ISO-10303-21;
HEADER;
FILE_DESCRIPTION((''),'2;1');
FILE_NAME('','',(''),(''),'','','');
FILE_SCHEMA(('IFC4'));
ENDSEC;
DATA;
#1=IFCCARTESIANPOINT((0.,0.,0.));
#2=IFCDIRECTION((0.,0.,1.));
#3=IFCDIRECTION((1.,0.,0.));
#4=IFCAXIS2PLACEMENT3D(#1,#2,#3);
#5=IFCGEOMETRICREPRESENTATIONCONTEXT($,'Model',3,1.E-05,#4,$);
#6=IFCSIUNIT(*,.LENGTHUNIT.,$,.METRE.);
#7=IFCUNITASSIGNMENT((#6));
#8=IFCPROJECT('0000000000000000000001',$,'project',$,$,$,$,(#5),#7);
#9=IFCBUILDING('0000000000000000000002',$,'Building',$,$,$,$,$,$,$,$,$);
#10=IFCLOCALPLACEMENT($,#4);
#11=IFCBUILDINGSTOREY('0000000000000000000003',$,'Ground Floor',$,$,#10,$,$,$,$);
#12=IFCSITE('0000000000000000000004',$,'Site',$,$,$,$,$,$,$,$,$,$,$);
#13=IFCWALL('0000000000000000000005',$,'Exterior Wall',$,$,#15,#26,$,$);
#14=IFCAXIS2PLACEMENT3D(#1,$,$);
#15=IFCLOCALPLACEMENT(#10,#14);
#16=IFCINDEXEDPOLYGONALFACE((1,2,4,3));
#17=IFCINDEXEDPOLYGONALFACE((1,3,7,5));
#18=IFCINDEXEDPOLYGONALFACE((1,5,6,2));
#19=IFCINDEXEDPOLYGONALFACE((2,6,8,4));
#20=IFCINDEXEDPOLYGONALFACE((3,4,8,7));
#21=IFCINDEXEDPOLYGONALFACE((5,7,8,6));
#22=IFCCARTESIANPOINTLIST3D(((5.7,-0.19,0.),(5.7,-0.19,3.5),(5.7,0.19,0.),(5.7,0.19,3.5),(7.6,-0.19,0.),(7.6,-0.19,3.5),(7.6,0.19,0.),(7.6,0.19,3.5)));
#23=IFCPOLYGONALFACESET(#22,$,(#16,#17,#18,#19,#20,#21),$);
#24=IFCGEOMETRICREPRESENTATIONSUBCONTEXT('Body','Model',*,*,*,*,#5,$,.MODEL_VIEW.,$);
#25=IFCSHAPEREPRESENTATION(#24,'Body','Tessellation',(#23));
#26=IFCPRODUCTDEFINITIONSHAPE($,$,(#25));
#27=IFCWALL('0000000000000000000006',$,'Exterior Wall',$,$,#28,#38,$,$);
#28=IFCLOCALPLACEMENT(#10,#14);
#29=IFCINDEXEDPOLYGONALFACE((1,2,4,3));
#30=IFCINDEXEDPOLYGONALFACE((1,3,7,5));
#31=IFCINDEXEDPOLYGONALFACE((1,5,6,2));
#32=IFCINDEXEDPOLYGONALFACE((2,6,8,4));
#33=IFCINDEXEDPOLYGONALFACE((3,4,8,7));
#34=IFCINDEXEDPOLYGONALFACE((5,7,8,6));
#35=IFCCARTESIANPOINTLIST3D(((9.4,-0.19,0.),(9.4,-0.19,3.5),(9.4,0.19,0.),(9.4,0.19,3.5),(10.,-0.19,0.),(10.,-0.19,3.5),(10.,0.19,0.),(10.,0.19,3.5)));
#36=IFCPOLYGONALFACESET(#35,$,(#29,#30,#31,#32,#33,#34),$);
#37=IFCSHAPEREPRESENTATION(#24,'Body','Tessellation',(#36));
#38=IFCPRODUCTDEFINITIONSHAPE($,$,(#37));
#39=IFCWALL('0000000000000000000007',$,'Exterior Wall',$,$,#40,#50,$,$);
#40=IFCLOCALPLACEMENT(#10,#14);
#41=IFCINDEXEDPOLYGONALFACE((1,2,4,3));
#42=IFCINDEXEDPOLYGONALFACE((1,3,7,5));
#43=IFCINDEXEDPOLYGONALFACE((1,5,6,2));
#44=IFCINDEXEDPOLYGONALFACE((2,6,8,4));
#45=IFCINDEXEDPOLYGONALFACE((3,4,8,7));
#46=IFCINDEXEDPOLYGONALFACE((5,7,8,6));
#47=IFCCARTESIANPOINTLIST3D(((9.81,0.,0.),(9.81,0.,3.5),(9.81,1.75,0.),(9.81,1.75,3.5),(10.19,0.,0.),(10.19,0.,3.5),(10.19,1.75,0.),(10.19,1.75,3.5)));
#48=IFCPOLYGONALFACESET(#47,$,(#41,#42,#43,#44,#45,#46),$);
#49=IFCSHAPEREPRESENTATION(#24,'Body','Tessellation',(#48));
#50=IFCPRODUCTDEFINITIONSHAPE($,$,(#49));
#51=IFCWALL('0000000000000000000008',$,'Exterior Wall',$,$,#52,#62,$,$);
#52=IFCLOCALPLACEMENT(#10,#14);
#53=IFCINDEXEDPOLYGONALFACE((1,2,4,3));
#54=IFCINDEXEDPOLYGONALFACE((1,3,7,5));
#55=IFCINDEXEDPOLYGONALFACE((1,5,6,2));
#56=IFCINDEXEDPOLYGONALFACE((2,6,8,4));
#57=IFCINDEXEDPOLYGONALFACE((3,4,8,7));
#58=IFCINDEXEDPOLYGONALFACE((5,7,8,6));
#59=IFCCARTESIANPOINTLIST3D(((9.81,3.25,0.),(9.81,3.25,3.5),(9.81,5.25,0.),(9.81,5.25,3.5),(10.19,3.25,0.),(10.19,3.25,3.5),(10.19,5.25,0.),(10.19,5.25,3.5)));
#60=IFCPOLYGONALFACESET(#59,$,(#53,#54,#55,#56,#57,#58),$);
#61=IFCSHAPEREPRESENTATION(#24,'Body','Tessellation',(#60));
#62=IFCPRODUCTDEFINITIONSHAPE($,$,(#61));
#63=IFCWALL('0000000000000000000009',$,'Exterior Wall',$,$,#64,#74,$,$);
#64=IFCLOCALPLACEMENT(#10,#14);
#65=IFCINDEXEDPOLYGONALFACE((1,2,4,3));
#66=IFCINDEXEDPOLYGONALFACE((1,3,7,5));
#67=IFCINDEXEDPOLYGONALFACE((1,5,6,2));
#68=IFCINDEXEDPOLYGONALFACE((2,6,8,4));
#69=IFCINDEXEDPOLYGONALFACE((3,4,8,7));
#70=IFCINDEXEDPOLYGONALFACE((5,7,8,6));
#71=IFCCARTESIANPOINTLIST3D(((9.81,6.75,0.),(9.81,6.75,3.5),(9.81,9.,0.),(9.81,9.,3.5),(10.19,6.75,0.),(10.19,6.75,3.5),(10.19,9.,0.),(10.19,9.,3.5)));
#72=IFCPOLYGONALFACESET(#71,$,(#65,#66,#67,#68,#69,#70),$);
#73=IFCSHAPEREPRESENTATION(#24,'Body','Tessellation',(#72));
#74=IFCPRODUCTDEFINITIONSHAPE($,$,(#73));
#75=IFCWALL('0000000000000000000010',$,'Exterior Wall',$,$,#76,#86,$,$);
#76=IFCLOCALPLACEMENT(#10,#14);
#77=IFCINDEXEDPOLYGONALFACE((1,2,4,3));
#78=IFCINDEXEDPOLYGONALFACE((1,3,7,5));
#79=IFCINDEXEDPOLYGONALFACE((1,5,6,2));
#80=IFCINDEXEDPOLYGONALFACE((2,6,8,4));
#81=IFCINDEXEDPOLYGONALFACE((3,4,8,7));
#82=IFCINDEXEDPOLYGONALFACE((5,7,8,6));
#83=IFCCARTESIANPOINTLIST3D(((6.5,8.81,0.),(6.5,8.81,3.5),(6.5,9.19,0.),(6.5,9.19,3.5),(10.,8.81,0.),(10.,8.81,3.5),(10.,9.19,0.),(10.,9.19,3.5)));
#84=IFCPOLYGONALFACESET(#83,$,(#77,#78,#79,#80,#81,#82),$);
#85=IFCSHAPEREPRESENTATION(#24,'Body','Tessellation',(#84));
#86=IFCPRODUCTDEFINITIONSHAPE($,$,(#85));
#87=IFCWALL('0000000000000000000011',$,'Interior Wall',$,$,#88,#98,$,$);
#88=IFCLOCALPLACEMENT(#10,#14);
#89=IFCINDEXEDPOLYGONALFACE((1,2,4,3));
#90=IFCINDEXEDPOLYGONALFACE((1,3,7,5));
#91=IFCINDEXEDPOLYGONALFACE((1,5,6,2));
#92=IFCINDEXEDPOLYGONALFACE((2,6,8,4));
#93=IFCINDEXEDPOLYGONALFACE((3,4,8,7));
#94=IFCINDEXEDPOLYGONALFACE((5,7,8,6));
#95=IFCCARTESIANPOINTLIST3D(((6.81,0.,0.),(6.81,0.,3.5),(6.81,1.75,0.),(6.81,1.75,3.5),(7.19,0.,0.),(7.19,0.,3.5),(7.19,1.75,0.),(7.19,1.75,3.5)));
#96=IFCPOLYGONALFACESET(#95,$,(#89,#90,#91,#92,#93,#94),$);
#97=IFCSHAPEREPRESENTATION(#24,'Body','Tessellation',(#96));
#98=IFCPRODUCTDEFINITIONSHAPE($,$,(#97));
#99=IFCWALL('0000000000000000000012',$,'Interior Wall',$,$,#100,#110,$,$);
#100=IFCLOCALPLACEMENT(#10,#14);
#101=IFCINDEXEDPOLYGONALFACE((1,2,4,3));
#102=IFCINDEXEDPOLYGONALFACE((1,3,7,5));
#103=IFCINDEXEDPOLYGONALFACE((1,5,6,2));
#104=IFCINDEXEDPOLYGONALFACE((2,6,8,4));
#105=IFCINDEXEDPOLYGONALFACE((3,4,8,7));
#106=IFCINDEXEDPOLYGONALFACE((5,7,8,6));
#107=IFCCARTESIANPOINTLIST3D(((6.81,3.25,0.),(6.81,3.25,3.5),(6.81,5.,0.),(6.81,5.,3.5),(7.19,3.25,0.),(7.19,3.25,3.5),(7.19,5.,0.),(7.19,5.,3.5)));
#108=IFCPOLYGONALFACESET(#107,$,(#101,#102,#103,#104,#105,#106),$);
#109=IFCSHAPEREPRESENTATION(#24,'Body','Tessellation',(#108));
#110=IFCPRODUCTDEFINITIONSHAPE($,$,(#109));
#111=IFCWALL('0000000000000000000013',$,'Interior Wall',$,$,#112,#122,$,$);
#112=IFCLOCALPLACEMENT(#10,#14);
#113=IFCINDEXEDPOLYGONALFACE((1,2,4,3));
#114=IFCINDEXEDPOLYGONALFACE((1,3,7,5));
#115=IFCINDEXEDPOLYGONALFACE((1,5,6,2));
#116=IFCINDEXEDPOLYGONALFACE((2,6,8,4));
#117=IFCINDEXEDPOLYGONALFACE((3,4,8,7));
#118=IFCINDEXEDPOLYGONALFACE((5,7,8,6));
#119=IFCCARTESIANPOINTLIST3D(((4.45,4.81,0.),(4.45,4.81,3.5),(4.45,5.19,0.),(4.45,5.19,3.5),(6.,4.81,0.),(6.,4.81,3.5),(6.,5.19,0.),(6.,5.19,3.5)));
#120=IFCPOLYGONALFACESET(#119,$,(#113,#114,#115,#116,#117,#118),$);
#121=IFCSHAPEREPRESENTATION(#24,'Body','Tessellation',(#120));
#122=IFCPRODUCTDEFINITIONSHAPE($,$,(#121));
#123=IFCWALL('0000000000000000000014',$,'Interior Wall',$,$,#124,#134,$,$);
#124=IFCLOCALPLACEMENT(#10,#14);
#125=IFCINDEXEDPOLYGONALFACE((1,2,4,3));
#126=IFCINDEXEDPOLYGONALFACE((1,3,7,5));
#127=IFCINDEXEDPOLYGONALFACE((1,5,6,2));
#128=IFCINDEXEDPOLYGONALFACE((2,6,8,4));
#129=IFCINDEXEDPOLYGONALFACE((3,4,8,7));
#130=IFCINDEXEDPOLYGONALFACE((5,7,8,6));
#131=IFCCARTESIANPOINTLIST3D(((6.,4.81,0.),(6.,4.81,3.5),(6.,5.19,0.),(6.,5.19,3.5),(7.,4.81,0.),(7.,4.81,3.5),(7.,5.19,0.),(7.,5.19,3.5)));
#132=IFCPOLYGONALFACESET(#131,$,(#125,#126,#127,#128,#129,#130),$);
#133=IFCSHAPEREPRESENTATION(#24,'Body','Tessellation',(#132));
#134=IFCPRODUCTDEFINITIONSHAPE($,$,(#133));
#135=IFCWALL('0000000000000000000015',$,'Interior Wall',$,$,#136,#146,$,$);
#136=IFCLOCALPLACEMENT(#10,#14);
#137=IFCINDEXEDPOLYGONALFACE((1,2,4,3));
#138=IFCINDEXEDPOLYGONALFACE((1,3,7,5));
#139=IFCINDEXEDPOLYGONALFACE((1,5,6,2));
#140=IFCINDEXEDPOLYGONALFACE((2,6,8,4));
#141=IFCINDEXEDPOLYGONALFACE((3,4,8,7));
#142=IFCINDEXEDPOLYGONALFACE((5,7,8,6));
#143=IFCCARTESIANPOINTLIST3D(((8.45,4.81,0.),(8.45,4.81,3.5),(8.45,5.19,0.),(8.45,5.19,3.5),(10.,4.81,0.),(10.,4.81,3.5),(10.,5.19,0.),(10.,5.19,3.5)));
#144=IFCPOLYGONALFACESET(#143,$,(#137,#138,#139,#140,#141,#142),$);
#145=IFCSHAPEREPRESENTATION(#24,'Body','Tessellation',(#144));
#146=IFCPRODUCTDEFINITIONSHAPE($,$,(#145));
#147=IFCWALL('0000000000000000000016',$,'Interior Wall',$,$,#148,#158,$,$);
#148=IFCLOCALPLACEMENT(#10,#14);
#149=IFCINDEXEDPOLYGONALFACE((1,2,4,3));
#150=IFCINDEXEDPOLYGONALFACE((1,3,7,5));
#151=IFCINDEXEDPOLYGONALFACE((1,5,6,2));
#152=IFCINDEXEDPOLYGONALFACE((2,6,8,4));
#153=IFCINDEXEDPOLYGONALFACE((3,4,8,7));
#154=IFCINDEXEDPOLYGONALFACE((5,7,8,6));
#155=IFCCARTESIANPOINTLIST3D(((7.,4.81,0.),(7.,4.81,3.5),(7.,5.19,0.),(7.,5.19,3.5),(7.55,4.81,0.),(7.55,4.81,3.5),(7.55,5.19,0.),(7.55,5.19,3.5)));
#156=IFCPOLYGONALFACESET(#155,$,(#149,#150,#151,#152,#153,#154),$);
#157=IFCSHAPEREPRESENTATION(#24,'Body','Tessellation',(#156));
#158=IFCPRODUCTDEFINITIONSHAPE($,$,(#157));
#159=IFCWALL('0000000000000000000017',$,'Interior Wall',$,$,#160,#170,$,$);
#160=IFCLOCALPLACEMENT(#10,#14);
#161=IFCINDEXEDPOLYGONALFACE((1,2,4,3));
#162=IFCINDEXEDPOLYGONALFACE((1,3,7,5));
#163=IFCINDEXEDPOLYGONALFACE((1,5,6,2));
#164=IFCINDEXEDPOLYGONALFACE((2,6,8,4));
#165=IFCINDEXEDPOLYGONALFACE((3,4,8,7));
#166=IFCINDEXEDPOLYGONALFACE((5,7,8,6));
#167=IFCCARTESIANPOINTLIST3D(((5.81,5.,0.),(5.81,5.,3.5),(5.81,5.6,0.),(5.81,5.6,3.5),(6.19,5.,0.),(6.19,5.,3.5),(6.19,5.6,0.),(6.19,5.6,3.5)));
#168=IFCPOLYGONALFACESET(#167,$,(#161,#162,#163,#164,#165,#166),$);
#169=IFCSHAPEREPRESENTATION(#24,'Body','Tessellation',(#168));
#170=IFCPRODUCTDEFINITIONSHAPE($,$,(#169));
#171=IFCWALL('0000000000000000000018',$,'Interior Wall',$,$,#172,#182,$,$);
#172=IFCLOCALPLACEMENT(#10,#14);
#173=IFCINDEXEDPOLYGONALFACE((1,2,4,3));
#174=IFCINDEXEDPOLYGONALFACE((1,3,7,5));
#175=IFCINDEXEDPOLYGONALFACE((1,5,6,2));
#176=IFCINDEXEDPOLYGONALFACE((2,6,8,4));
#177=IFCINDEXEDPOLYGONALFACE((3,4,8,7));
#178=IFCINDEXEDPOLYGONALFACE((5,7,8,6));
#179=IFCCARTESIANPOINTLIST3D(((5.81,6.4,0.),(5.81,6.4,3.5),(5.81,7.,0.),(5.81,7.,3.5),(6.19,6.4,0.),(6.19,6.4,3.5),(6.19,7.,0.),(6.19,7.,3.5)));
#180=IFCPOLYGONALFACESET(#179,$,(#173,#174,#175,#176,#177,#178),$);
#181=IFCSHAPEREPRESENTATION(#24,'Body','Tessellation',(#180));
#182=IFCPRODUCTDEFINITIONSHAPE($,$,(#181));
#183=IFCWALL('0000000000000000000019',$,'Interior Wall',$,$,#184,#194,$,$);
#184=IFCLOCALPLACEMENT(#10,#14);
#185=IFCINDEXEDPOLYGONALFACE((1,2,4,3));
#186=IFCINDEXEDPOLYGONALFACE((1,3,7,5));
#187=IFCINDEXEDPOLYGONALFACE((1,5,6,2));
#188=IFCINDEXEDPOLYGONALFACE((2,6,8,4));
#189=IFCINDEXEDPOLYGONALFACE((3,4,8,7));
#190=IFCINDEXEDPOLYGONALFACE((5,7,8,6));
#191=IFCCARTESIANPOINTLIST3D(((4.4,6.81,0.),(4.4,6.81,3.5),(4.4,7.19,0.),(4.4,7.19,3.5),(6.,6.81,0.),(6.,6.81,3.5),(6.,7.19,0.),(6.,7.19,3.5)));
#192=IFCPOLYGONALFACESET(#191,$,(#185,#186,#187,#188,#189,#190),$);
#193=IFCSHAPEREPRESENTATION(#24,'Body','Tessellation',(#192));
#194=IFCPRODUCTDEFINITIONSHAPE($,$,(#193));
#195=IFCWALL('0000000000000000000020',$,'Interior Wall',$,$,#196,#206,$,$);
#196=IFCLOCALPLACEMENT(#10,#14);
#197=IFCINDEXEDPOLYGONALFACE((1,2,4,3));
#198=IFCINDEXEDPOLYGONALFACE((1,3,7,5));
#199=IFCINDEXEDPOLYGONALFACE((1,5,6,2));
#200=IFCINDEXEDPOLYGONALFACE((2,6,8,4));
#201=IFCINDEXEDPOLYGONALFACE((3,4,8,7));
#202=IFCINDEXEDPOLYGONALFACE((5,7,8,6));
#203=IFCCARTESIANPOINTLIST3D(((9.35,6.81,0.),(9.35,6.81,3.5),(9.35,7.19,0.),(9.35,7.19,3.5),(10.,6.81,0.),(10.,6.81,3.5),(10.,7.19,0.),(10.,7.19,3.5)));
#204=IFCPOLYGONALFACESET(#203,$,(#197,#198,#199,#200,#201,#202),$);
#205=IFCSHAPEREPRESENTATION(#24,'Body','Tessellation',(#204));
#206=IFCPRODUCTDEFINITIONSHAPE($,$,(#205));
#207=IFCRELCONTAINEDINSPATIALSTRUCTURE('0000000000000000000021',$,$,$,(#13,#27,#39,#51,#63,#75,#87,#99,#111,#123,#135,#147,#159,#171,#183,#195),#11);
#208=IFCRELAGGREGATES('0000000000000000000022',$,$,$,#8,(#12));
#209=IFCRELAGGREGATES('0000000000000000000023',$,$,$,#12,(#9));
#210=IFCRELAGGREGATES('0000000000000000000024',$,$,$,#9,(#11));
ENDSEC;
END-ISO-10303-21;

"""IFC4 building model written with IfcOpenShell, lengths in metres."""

from ifc_helpers import new_model, si_unit, frame, origin_with_axes, place, context, subcontext, project, spatial, indexed_curve, outline, extrude, element, save


model = new_model("IFC4")

# Units and contexts
model_context = context("Model", 3, precision=1e-05, world=origin_with_axes())
body_context = subcontext(model_context, "Body", "Model", "MODEL_VIEW")
ifc_project = project(units=[si_unit("LENGTHUNIT", "METRE")], contexts=[model_context])

# Site, building, storey
site = spatial("IfcSite", under=ifc_project, Name="Site")
building = spatial("IfcBuilding", under=site, Name="Building")
storey_placement = place(None, origin_with_axes())
storey = spatial("IfcBuildingStorey", under=building, at=storey_placement, Name="Ground Floor")

# Walls
wall_1_placement = place(storey_placement, frame((5.7, 0.0, 0.0), z_axis=(0.0, 0.0, 1.0), x_axis=(1.0, 0.0, 0.0)))
element("IfcWall", 1, at=wall_1_placement, inside=storey, Name="Exterior Wall", context=body_context, shape_type="SweptSolid", body=[
    extrude(outline(indexed_curve([(0.0, 0.0), (0.0, 0.38), (1.9, 0.38), (1.9, 0.0), (0.0, 0.0)], self_intersect=False)), frame((0.0, -0.19, 0.0), z_axis=(0.0, 0.0, 1.0), x_axis=(1.0, 0.0, 0.0)), (0.0, 0.0, 1.0), 3.5),
])
wall_2_placement = place(storey_placement, frame((9.4, 0.0, 0.0), z_axis=(0.0, 0.0, 1.0), x_axis=(1.0, 0.0, 0.0)))
element("IfcWall", 2, at=wall_2_placement, inside=storey, Name="Exterior Wall", context=body_context, shape_type="SweptSolid", body=[
    extrude(outline(indexed_curve([(0.0, 0.0), (0.0, 0.38), (0.6, 0.38), (0.6, 0.0), (0.0, 0.0)], self_intersect=False)), frame((0.0, -0.19, 0.0), z_axis=(0.0, 0.0, 1.0), x_axis=(1.0, 0.0, 0.0)), (0.0, 0.0, 1.0), 3.5),
])
wall_3_placement = place(storey_placement, frame((10.0, 0.0, 0.0), z_axis=(0.0, 0.0, 1.0), x_axis=(0.0, 1.0, 0.0)))
element("IfcWall", 3, at=wall_3_placement, inside=storey, Name="Exterior Wall", context=body_context, shape_type="SweptSolid", body=[
    extrude(outline(indexed_curve([(0.0, 0.0), (0.0, 0.38), (1.75, 0.38), (1.75, 0.0), (0.0, 0.0)], self_intersect=False)), frame((0.0, -0.19, 0.0), z_axis=(0.0, 0.0, 1.0), x_axis=(1.0, 0.0, 0.0)), (0.0, 0.0, 1.0), 3.5),
])
wall_4_placement = place(storey_placement, frame((10.0, 3.25, 0.0), z_axis=(0.0, 0.0, 1.0), x_axis=(0.0, 1.0, 0.0)))
element("IfcWall", 4, at=wall_4_placement, inside=storey, Name="Exterior Wall", context=body_context, shape_type="SweptSolid", body=[
    extrude(outline(indexed_curve([(0.0, 0.0), (0.0, 0.38), (2.0, 0.38), (2.0, 0.0), (0.0, 0.0)], self_intersect=False)), frame((0.0, -0.19, 0.0), z_axis=(0.0, 0.0, 1.0), x_axis=(1.0, 0.0, 0.0)), (0.0, 0.0, 1.0), 3.5),
])
wall_5_placement = place(storey_placement, frame((10.0, 6.75, 0.0), z_axis=(0.0, 0.0, 1.0), x_axis=(0.0, 1.0, 0.0)))
element("IfcWall", 5, at=wall_5_placement, inside=storey, Name="Exterior Wall", context=body_context, shape_type="SweptSolid", body=[
    extrude(outline(indexed_curve([(0.0, 0.0), (0.0, 0.38), (2.25, 0.38), (2.25, 0.0), (0.0, 0.0)], self_intersect=False)), frame((0.0, -0.19, 0.0), z_axis=(0.0, 0.0, 1.0), x_axis=(1.0, 0.0, 0.0)), (0.0, 0.0, 1.0), 3.5),
])
wall_6_placement = place(storey_placement, frame((10.0, 9.0, 0.0), z_axis=(0.0, 0.0, 1.0), x_axis=(-1.0, 0.0, 0.0)))
element("IfcWall", 6, at=wall_6_placement, inside=storey, Name="Exterior Wall", context=body_context, shape_type="SweptSolid", body=[
    extrude(outline(indexed_curve([(0.0, 0.0), (0.0, 0.38), (3.5, 0.38), (3.5, 0.0), (0.0, 0.0)], self_intersect=False)), frame((0.0, -0.19, 0.0), z_axis=(0.0, 0.0, 1.0), x_axis=(1.0, 0.0, 0.0)), (0.0, 0.0, 1.0), 3.5),
])
for number, where, z_axis, x_axis, name in (
    (7, (7.0, 0.0, 0.0), (0.0, 0.0, 1.0), (0.0, 1.0, 0.0), "Interior Wall"),
    (8, (7.0, 3.25, 0.0), (0.0, 0.0, 1.0), (0.0, 1.0, 0.0), "Interior Wall"),
):
    element("IfcWall", number, at=place(storey_placement, frame(where, z_axis=z_axis, x_axis=x_axis)), inside=storey, Name=name, context=body_context, shape_type="SweptSolid", body=[
        extrude(outline(indexed_curve([(0.0, 0.0), (0.0, 0.38), (1.75, 0.38), (1.75, 0.0), (0.0, 0.0)], self_intersect=False)), frame((0.0, -0.19, 0.0), z_axis=(0.0, 0.0, 1.0), x_axis=(1.0, 0.0, 0.0)), (0.0, 0.0, 1.0), 3.5),
    ])
wall_7_placement = place(storey_placement, frame((6.0, 5.0, 0.0), z_axis=(0.0, 0.0, 1.0), x_axis=(-1.0, 0.0, 0.0)))
element("IfcWall", 9, at=wall_7_placement, inside=storey, Name="Interior Wall", context=body_context, shape_type="SweptSolid", body=[
    extrude(outline(indexed_curve([(0.0, 0.0), (0.0, 0.38), (1.55, 0.38), (1.55, 0.0), (0.0, 0.0)], self_intersect=False)), frame((0.0, -0.19, 0.0), z_axis=(0.0, 0.0, 1.0), x_axis=(1.0, 0.0, 0.0)), (0.0, 0.0, 1.0), 3.5),
])
wall_8_placement = place(storey_placement, frame((7.0, 5.0, 0.0), z_axis=(0.0, 0.0, 1.0), x_axis=(-1.0, 0.0, 0.0)))
element("IfcWall", 10, at=wall_8_placement, inside=storey, Name="Interior Wall", context=body_context, shape_type="SweptSolid", body=[
    extrude(outline(indexed_curve([(0.0, 0.0), (0.0, 0.38), (1.0, 0.38), (1.0, 0.0), (0.0, 0.0)], self_intersect=False)), frame((0.0, -0.19, 0.0), z_axis=(0.0, 0.0, 1.0), x_axis=(1.0, 0.0, 0.0)), (0.0, 0.0, 1.0), 3.5),
])
wall_9_placement = place(storey_placement, frame((10.0, 5.0, 0.0), z_axis=(0.0, 0.0, 1.0), x_axis=(-1.0, 0.0, 0.0)))
element("IfcWall", 11, at=wall_9_placement, inside=storey, Name="Interior Wall", context=body_context, shape_type="SweptSolid", body=[
    extrude(outline(indexed_curve([(0.0, 0.0), (0.0, 0.38), (1.55, 0.38), (1.55, 0.0), (0.0, 0.0)], self_intersect=False)), frame((0.0, -0.19, 0.0), z_axis=(0.0, 0.0, 1.0), x_axis=(1.0, 0.0, 0.0)), (0.0, 0.0, 1.0), 3.5),
])
wall_10_placement = place(storey_placement, frame((7.55, 5.0, 0.0), z_axis=(0.0, 0.0, 1.0), x_axis=(-1.0, 0.0, 0.0)))
element("IfcWall", 12, at=wall_10_placement, inside=storey, Name="Interior Wall", context=body_context, shape_type="SweptSolid", body=[
    extrude(outline(indexed_curve([(0.0, 0.0), (0.0, 0.38), (0.55, 0.38), (0.55, 0.0), (0.0, 0.0)], self_intersect=False)), frame((0.0, -0.19, 0.0), z_axis=(0.0, 0.0, 1.0), x_axis=(1.0, 0.0, 0.0)), (0.0, 0.0, 1.0), 3.5),
])
for number, where, z_axis, x_axis, name in (
    (13, (6.0, 5.0, 0.0), (0.0, 0.0, 1.0), (0.0, 1.0, 0.0), "Interior Wall"),
    (14, (6.0, 6.4, 0.0), (0.0, 0.0, 1.0), (0.0, 1.0, 0.0), "Interior Wall"),
):
    element("IfcWall", number, at=place(storey_placement, frame(where, z_axis=z_axis, x_axis=x_axis)), inside=storey, Name=name, context=body_context, shape_type="SweptSolid", body=[
        extrude(outline(indexed_curve([(0.0, 0.0), (0.0, 0.38), (0.6, 0.38), (0.6, 0.0), (0.0, 0.0)], self_intersect=False)), frame((0.0, -0.19, 0.0), z_axis=(0.0, 0.0, 1.0), x_axis=(1.0, 0.0, 0.0)), (0.0, 0.0, 1.0), 3.5),
    ])
wall_11_placement = place(storey_placement, frame((6.0, 7.0, 0.0), z_axis=(0.0, 0.0, 1.0), x_axis=(-1.0, 0.0, 0.0)))
element("IfcWall", 15, at=wall_11_placement, inside=storey, Name="Interior Wall", context=body_context, shape_type="SweptSolid", body=[
    extrude(outline(indexed_curve([(0.0, 0.0), (0.0, 0.38), (1.6, 0.38), (1.6, 0.0), (0.0, 0.0)], self_intersect=False)), frame((0.0, -0.19, 0.0), z_axis=(0.0, 0.0, 1.0), x_axis=(1.0, 0.0, 0.0)), (0.0, 0.0, 1.0), 3.5),
])
for number, where, z_axis, x_axis, name in (
    (16, (10.0, 7.0, 0.0), (0.0, 0.0, 1.0), (-1.0, 0.0, 0.0), "Interior Wall"),
):
    element("IfcWall", number, at=place(storey_placement, frame(where, z_axis=z_axis, x_axis=x_axis)), inside=storey, Name=name, context=body_context, shape_type="SweptSolid", body=[
        extrude(outline(indexed_curve([(0.0, 0.0), (0.0, 0.38), (0.65, 0.38), (0.65, 0.0), (0.0, 0.0)], self_intersect=False)), frame((0.0, -0.19, 0.0), z_axis=(0.0, 0.0, 1.0), x_axis=(1.0, 0.0, 0.0)), (0.0, 0.0, 1.0), 3.5),
    ])

save(model, "model.ifc")
